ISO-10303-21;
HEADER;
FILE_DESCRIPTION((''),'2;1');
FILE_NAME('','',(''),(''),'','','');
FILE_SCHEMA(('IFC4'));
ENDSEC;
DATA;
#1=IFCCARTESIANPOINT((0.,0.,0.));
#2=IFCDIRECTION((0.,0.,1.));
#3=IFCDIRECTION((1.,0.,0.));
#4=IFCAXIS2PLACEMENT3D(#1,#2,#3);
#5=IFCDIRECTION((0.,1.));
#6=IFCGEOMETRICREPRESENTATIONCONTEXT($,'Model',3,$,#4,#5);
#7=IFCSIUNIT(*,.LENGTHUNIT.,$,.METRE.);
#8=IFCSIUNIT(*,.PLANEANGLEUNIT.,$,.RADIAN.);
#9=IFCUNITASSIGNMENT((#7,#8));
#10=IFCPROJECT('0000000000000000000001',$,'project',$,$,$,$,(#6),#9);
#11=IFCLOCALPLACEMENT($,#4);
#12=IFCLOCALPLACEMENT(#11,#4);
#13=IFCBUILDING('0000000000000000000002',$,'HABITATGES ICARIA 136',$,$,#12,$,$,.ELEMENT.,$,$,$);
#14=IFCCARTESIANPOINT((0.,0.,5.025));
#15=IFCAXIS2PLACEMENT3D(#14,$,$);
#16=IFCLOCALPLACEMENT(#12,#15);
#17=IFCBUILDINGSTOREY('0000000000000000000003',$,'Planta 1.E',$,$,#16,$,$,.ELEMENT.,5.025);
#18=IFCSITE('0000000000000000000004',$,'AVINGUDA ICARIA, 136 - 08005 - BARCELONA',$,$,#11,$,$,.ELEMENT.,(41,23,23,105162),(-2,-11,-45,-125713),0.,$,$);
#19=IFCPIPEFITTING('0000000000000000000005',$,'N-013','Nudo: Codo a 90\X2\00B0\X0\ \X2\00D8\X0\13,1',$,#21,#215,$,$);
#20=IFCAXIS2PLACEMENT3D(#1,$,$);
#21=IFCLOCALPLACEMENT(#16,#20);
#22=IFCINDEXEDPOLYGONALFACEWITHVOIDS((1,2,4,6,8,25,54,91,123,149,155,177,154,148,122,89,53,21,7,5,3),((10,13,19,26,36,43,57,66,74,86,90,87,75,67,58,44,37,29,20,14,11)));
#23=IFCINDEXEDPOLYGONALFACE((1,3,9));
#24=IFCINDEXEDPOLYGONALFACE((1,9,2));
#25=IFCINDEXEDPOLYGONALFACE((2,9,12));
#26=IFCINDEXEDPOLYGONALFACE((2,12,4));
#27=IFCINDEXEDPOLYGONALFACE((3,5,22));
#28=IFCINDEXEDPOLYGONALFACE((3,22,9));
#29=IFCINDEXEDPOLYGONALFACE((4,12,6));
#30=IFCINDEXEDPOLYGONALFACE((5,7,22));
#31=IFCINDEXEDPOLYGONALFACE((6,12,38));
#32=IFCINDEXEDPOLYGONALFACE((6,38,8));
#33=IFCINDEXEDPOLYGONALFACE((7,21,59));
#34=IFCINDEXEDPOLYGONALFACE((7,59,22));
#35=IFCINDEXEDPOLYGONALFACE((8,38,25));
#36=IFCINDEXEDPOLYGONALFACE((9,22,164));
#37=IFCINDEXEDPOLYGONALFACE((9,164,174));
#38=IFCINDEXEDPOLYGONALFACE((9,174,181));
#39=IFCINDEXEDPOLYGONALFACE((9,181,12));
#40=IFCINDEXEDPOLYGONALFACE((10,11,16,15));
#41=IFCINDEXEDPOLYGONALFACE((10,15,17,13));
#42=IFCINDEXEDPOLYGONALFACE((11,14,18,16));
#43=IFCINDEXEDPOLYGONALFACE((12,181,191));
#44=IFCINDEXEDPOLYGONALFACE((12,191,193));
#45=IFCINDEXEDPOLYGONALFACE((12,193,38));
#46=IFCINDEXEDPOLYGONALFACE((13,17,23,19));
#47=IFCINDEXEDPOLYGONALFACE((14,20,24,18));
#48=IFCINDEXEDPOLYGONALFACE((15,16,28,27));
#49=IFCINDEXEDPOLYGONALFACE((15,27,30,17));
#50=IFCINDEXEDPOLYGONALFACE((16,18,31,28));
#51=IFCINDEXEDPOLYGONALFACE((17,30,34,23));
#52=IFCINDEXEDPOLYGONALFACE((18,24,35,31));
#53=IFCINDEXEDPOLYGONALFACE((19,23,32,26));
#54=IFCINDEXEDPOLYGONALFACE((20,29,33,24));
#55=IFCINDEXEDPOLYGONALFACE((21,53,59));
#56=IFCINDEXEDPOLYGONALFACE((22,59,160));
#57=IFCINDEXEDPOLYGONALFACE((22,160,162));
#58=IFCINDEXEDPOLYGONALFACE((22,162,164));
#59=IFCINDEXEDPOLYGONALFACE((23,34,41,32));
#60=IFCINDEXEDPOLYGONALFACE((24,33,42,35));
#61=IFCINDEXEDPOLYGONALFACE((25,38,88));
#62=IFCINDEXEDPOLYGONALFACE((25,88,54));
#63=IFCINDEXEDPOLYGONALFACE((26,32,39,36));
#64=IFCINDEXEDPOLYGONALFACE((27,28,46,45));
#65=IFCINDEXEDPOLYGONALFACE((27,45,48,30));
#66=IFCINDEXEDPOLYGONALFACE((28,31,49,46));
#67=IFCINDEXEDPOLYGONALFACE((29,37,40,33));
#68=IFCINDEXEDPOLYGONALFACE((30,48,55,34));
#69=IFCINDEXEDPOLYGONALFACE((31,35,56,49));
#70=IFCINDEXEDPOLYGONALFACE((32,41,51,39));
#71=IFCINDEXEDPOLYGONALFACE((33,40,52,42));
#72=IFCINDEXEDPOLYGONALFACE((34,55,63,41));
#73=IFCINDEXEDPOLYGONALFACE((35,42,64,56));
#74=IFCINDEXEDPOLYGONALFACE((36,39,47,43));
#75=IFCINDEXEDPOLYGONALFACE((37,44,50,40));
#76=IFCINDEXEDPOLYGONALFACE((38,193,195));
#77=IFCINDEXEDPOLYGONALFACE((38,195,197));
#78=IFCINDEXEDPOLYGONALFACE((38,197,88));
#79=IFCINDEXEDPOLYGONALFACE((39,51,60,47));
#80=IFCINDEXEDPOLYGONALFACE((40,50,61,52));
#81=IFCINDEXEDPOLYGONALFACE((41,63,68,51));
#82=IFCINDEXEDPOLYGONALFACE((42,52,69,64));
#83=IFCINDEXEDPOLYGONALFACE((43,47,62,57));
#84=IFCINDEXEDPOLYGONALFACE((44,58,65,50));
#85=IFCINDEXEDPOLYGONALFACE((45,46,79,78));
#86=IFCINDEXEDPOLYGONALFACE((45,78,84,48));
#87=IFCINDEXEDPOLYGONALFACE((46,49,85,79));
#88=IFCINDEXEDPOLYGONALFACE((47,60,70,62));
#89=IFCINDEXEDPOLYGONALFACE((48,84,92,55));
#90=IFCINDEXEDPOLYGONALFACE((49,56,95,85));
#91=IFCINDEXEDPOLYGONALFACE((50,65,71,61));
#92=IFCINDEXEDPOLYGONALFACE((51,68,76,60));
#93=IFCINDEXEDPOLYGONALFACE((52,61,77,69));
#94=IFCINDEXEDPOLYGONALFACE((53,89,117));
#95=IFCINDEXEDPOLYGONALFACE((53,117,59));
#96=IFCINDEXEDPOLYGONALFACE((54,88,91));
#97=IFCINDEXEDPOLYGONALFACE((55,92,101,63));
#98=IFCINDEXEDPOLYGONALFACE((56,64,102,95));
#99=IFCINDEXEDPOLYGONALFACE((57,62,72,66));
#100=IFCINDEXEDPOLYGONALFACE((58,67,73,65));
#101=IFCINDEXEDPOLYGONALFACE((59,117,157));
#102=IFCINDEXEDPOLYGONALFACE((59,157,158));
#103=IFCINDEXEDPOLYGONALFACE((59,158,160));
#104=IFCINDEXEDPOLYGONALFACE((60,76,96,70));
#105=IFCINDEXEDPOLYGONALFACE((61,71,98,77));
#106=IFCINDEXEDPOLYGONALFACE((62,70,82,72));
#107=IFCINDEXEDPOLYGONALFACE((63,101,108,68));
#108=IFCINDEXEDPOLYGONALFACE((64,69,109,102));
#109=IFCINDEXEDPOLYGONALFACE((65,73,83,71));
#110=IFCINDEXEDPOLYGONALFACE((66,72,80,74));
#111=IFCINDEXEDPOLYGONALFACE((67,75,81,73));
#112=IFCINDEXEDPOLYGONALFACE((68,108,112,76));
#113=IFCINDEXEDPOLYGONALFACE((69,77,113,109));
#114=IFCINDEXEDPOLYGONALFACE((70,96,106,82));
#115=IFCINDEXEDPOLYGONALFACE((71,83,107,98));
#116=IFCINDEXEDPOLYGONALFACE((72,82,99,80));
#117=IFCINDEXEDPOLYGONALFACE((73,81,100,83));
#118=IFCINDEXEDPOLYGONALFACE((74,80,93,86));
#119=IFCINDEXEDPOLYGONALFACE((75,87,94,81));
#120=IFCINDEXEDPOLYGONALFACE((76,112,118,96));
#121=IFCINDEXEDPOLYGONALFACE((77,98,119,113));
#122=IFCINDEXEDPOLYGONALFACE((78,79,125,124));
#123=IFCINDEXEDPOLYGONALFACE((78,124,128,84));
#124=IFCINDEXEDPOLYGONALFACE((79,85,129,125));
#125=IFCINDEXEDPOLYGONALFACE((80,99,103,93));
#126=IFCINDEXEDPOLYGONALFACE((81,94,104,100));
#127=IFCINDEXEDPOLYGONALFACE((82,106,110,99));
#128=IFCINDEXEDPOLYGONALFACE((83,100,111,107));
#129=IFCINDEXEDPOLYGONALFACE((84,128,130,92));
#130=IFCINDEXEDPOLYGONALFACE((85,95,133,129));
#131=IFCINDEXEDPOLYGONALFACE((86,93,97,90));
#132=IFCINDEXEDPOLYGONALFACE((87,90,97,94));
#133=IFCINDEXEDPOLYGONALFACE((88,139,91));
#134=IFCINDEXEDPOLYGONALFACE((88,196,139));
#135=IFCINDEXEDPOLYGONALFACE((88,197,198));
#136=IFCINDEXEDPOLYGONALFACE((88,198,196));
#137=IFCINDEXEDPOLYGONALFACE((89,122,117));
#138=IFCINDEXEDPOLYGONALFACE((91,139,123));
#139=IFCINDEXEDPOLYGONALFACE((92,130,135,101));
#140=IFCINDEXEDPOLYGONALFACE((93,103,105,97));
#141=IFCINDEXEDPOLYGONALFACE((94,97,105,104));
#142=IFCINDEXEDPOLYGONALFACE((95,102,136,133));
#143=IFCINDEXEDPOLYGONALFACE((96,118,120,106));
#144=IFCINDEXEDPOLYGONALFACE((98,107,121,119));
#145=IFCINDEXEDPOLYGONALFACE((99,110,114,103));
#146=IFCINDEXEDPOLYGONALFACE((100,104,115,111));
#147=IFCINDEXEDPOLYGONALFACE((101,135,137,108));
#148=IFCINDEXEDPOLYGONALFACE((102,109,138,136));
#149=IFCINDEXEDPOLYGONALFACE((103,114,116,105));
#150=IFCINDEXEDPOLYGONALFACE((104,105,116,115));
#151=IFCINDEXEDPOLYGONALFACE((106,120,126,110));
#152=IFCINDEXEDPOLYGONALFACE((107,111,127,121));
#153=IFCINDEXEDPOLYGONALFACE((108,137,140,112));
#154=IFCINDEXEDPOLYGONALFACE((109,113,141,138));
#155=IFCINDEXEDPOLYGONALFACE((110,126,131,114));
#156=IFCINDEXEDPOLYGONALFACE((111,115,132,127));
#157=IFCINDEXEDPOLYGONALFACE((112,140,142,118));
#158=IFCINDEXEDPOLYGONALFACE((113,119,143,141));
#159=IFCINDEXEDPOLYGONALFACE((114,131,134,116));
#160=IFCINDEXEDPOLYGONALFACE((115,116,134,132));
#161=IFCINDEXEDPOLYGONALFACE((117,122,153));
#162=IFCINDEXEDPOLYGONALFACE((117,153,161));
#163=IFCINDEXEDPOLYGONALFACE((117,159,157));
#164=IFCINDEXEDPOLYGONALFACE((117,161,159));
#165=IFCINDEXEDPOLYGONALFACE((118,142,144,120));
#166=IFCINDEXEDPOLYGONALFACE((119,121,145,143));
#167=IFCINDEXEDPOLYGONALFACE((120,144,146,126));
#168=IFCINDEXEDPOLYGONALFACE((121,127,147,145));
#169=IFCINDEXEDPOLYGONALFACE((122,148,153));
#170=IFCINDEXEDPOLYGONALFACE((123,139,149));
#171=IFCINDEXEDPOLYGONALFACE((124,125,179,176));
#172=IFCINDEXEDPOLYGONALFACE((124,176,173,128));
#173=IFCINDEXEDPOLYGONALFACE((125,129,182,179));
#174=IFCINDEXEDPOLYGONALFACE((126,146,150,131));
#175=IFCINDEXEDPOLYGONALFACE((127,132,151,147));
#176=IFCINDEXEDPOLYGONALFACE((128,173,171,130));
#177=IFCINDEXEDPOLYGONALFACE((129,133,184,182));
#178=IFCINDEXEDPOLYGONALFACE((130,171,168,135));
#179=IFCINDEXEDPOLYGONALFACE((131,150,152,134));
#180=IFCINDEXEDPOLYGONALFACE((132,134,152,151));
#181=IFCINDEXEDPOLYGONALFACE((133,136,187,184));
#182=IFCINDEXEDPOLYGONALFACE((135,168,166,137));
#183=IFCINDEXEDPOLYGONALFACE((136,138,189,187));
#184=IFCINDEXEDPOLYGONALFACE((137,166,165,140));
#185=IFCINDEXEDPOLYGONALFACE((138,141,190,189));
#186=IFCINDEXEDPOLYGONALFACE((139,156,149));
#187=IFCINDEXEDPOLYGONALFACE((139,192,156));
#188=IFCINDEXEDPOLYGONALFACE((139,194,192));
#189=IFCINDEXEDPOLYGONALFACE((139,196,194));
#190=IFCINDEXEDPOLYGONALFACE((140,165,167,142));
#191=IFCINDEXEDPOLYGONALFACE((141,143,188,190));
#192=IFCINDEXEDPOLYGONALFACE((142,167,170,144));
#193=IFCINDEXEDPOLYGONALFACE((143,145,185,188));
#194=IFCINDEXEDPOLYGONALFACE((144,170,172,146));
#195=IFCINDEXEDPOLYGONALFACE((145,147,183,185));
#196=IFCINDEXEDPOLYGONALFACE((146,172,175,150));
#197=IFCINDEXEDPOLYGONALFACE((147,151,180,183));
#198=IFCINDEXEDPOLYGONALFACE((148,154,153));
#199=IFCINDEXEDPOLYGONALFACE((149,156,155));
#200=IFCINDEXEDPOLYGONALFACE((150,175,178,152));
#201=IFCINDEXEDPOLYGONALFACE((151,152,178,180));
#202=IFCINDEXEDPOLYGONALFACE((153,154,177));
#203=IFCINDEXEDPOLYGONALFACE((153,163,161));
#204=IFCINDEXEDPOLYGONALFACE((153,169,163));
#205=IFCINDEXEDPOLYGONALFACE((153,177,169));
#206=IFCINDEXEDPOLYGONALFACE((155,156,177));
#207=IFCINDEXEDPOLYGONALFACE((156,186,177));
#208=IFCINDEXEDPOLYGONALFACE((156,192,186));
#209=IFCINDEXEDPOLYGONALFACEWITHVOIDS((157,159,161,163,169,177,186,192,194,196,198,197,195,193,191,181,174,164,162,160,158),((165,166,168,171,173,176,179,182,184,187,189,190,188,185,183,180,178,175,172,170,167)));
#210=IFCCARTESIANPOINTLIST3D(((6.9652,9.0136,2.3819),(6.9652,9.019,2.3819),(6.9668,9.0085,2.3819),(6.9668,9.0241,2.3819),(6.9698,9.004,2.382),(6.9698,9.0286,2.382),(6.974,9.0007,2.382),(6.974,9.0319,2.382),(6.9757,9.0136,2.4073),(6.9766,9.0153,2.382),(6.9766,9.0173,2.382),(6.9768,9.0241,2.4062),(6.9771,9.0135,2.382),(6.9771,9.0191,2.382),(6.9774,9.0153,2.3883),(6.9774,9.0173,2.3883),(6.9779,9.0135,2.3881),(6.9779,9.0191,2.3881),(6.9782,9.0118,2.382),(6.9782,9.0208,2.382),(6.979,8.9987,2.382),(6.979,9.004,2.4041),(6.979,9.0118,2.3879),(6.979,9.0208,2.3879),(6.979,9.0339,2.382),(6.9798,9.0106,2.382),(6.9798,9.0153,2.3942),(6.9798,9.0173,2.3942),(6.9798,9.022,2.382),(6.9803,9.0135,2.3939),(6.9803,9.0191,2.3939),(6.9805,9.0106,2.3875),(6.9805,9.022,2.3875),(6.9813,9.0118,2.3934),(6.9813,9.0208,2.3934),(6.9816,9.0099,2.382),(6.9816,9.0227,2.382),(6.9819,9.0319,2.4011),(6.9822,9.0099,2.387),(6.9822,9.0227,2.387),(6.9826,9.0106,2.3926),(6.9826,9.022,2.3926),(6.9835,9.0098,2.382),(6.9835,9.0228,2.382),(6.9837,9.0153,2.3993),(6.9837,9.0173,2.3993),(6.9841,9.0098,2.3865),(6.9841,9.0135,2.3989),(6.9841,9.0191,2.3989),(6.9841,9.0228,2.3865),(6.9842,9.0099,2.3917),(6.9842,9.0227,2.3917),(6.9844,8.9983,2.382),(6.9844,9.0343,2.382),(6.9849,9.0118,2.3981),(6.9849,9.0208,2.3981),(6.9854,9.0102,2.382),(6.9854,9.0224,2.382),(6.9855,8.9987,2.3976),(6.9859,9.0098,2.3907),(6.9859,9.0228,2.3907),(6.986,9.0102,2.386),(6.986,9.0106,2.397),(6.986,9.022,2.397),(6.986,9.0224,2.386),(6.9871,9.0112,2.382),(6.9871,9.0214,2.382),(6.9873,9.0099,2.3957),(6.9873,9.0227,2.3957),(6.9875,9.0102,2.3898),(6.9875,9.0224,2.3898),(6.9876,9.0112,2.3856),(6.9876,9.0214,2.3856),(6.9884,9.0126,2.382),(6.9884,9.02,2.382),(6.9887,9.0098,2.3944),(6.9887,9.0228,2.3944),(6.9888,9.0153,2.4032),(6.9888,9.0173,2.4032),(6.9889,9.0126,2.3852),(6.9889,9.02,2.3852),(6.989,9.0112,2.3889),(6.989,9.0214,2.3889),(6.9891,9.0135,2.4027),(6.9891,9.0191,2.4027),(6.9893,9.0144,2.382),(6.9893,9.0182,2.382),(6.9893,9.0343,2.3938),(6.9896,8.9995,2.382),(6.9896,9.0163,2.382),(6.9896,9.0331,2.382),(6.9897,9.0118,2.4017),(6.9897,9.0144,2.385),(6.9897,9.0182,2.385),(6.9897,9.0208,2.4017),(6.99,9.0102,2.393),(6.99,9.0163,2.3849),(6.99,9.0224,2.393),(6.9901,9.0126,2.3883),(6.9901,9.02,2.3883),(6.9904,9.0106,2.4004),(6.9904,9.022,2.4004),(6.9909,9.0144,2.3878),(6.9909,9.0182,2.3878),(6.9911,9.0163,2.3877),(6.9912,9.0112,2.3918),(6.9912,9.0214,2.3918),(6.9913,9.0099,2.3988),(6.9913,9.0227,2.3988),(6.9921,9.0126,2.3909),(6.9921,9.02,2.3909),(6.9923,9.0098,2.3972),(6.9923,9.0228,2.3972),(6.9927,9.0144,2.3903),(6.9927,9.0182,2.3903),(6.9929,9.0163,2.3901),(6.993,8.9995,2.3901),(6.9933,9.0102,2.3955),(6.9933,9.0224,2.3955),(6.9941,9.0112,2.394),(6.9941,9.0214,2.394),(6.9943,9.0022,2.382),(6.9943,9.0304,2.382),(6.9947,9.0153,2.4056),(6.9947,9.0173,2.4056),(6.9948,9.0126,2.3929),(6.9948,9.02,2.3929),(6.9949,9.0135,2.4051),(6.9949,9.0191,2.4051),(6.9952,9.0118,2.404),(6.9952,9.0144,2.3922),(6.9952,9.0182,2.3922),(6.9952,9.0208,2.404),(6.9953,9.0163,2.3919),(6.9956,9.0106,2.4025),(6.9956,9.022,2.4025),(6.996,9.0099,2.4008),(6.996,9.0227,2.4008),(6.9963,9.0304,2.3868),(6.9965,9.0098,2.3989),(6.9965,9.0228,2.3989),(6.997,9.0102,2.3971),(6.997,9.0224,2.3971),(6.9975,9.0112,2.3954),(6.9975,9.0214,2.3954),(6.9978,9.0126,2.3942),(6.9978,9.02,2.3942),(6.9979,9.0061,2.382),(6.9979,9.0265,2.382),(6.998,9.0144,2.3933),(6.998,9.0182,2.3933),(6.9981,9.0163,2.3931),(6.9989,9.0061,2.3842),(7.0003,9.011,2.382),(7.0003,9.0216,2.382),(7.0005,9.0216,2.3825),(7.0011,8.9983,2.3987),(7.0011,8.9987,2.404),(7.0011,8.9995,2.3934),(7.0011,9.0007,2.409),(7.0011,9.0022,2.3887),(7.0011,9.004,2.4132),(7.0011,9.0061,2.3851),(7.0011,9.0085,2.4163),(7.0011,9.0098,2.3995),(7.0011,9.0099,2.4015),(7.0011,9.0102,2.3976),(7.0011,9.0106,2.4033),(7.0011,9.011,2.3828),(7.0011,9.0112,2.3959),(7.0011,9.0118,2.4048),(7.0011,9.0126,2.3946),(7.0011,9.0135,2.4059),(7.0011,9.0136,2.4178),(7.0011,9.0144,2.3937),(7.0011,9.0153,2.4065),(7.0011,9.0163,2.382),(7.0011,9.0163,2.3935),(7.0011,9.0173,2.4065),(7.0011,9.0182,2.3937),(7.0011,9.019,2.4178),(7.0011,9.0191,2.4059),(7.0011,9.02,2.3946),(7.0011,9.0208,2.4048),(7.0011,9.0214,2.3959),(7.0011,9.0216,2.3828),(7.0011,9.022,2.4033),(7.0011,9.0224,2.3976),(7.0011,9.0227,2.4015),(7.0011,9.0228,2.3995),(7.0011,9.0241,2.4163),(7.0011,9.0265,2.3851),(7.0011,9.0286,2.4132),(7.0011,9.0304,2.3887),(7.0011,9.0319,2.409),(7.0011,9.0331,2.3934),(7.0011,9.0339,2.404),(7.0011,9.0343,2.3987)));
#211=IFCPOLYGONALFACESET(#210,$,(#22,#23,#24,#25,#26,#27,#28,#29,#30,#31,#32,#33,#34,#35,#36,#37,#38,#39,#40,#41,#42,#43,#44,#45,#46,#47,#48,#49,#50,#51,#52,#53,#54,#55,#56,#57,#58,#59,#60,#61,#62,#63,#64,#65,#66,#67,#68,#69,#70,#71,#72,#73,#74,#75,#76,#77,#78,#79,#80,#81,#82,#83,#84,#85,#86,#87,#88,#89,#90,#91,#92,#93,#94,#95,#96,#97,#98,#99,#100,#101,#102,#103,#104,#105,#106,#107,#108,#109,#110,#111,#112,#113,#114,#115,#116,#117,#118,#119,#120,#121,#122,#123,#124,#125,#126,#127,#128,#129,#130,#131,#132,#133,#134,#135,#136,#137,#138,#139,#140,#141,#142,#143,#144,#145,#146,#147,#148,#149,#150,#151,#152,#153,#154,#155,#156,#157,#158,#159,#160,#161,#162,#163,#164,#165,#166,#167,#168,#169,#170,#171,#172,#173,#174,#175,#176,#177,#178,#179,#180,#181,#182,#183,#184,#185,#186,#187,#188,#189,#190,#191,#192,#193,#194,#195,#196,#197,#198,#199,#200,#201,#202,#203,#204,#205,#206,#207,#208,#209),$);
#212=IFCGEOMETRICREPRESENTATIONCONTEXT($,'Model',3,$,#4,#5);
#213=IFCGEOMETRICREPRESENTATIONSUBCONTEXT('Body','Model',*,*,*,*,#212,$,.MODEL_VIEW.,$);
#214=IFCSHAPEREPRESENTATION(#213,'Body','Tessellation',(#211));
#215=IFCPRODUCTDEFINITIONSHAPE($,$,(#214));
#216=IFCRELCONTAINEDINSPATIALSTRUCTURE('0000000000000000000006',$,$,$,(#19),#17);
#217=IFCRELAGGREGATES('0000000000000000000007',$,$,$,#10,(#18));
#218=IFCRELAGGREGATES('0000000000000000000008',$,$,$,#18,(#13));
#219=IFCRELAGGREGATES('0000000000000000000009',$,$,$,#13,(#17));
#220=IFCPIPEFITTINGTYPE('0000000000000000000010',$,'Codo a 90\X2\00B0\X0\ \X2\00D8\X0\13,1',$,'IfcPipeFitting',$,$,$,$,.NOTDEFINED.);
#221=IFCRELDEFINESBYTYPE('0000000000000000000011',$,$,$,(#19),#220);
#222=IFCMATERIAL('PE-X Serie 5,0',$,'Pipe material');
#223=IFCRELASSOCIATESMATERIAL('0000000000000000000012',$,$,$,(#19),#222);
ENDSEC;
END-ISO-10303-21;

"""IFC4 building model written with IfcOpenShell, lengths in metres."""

from ifc_helpers import new_model, entity, si_unit, direction, frame, origin_with_axes, place, context, subcontext, project, spatial, source, transform, mapped, material, type_object, element, save


model = new_model("IFC4")

# Units and contexts
model_context_1 = context("Model", 3, world=origin_with_axes(), true_north=direction((0.0, 1.0)))
model_context_2 = context("Model", 3, world=origin_with_axes(), true_north=direction((0.0, 1.0)))
body_context_1 = subcontext(model_context_2, "Body", "Model", "MODEL_VIEW")
ifc_project = project(units=[si_unit("LENGTHUNIT", "METRE"), si_unit("PLANEANGLEUNIT", "RADIAN")], contexts=[model_context_1])

# Site, building, storey
site_placement = place(None, origin_with_axes())
site = spatial("IfcSite", under=ifc_project, at=site_placement, Name="AVINGUDA ICARIA, 136 - 08005 - BARCELONA", CompositionType="ELEMENT", RefLatitude=(41, 23, 23, 105162), RefLongitude=(-2, -11, -45, -125713), RefElevation=0.0)
building_placement = place(site_placement, origin_with_axes())
building = spatial("IfcBuilding", under=site, at=building_placement, Name="HABITATGES ICARIA 136", CompositionType="ELEMENT")
storey_placement = place(building_placement, frame((0.0, 0.0, 5.025)))
storey = spatial("IfcBuildingStorey", under=building, at=storey_placement, Name="Planta 1.E", CompositionType="ELEMENT", Elevation=5.025)

# Pipe fitting
ifc_material_1 = material(Name="PE-X Serie 5,0", Category="Pipe material")
placement_1 = place(None, origin_with_axes())
placement_2 = place(placement_1, origin_with_axes())
placement_3 = place(placement_2, frame((0.0, 0.0, 5.025)))
pipe_fitting_type_1 = type_object("IfcPipeFittingType", Name="Codo a 90° Ø13,1", ApplicableOccurrence="IfcPipeFitting", PredefinedType="NOTDEFINED")
shared_shape_1 = source(origin_with_axes(), body_context_1, "Body", "SweptSolid", [
    entity("IfcRevolvedAreaSolid", entity("IfcCircleHollowProfileDef", "AREA", None, entity("IfcAxis2Placement2D", entity("IfcCartesianPoint", [0.0, 0.0]), entity("IfcDirection", [1.0, 0.0])), 0.0181, 0.0115), entity("IfcAxis2Placement3D", entity("IfcCartesianPoint", [0.0181, 0.0, 0.0]), entity("IfcDirection", [-1.0, 0.0, 0.0]), entity("IfcDirection", [0.0, -1.0, 0.0])), entity("IfcAxis1Placement", entity("IfcCartesianPoint", [0.0181, 0.0, 0.0]), entity("IfcDirection", [0.0, 1.0, 0.0])), 1.570796),
])
pipe_fitting_1_placement = place(placement_3, origin_with_axes())
element("IfcPipeFitting", 1, at=pipe_fitting_1_placement, inside=storey, type_object=pipe_fitting_type_1, material=ifc_material_1, Name="N-013", Description="Nudo: Codo a 90° Ø13,1", context=body_context_1, shape_type="MappedRepresentation", body=[
    mapped(shared_shape_1, transform((6.983, 9.0163, 2.4), x_axis=(1.0, 0.0, 0.0), y_axis=(0.0, 0.0, 1.0), z_axis=(0.0, -1.0, 0.0), scale=1.0)),
])

save(model, "model.ifc")
